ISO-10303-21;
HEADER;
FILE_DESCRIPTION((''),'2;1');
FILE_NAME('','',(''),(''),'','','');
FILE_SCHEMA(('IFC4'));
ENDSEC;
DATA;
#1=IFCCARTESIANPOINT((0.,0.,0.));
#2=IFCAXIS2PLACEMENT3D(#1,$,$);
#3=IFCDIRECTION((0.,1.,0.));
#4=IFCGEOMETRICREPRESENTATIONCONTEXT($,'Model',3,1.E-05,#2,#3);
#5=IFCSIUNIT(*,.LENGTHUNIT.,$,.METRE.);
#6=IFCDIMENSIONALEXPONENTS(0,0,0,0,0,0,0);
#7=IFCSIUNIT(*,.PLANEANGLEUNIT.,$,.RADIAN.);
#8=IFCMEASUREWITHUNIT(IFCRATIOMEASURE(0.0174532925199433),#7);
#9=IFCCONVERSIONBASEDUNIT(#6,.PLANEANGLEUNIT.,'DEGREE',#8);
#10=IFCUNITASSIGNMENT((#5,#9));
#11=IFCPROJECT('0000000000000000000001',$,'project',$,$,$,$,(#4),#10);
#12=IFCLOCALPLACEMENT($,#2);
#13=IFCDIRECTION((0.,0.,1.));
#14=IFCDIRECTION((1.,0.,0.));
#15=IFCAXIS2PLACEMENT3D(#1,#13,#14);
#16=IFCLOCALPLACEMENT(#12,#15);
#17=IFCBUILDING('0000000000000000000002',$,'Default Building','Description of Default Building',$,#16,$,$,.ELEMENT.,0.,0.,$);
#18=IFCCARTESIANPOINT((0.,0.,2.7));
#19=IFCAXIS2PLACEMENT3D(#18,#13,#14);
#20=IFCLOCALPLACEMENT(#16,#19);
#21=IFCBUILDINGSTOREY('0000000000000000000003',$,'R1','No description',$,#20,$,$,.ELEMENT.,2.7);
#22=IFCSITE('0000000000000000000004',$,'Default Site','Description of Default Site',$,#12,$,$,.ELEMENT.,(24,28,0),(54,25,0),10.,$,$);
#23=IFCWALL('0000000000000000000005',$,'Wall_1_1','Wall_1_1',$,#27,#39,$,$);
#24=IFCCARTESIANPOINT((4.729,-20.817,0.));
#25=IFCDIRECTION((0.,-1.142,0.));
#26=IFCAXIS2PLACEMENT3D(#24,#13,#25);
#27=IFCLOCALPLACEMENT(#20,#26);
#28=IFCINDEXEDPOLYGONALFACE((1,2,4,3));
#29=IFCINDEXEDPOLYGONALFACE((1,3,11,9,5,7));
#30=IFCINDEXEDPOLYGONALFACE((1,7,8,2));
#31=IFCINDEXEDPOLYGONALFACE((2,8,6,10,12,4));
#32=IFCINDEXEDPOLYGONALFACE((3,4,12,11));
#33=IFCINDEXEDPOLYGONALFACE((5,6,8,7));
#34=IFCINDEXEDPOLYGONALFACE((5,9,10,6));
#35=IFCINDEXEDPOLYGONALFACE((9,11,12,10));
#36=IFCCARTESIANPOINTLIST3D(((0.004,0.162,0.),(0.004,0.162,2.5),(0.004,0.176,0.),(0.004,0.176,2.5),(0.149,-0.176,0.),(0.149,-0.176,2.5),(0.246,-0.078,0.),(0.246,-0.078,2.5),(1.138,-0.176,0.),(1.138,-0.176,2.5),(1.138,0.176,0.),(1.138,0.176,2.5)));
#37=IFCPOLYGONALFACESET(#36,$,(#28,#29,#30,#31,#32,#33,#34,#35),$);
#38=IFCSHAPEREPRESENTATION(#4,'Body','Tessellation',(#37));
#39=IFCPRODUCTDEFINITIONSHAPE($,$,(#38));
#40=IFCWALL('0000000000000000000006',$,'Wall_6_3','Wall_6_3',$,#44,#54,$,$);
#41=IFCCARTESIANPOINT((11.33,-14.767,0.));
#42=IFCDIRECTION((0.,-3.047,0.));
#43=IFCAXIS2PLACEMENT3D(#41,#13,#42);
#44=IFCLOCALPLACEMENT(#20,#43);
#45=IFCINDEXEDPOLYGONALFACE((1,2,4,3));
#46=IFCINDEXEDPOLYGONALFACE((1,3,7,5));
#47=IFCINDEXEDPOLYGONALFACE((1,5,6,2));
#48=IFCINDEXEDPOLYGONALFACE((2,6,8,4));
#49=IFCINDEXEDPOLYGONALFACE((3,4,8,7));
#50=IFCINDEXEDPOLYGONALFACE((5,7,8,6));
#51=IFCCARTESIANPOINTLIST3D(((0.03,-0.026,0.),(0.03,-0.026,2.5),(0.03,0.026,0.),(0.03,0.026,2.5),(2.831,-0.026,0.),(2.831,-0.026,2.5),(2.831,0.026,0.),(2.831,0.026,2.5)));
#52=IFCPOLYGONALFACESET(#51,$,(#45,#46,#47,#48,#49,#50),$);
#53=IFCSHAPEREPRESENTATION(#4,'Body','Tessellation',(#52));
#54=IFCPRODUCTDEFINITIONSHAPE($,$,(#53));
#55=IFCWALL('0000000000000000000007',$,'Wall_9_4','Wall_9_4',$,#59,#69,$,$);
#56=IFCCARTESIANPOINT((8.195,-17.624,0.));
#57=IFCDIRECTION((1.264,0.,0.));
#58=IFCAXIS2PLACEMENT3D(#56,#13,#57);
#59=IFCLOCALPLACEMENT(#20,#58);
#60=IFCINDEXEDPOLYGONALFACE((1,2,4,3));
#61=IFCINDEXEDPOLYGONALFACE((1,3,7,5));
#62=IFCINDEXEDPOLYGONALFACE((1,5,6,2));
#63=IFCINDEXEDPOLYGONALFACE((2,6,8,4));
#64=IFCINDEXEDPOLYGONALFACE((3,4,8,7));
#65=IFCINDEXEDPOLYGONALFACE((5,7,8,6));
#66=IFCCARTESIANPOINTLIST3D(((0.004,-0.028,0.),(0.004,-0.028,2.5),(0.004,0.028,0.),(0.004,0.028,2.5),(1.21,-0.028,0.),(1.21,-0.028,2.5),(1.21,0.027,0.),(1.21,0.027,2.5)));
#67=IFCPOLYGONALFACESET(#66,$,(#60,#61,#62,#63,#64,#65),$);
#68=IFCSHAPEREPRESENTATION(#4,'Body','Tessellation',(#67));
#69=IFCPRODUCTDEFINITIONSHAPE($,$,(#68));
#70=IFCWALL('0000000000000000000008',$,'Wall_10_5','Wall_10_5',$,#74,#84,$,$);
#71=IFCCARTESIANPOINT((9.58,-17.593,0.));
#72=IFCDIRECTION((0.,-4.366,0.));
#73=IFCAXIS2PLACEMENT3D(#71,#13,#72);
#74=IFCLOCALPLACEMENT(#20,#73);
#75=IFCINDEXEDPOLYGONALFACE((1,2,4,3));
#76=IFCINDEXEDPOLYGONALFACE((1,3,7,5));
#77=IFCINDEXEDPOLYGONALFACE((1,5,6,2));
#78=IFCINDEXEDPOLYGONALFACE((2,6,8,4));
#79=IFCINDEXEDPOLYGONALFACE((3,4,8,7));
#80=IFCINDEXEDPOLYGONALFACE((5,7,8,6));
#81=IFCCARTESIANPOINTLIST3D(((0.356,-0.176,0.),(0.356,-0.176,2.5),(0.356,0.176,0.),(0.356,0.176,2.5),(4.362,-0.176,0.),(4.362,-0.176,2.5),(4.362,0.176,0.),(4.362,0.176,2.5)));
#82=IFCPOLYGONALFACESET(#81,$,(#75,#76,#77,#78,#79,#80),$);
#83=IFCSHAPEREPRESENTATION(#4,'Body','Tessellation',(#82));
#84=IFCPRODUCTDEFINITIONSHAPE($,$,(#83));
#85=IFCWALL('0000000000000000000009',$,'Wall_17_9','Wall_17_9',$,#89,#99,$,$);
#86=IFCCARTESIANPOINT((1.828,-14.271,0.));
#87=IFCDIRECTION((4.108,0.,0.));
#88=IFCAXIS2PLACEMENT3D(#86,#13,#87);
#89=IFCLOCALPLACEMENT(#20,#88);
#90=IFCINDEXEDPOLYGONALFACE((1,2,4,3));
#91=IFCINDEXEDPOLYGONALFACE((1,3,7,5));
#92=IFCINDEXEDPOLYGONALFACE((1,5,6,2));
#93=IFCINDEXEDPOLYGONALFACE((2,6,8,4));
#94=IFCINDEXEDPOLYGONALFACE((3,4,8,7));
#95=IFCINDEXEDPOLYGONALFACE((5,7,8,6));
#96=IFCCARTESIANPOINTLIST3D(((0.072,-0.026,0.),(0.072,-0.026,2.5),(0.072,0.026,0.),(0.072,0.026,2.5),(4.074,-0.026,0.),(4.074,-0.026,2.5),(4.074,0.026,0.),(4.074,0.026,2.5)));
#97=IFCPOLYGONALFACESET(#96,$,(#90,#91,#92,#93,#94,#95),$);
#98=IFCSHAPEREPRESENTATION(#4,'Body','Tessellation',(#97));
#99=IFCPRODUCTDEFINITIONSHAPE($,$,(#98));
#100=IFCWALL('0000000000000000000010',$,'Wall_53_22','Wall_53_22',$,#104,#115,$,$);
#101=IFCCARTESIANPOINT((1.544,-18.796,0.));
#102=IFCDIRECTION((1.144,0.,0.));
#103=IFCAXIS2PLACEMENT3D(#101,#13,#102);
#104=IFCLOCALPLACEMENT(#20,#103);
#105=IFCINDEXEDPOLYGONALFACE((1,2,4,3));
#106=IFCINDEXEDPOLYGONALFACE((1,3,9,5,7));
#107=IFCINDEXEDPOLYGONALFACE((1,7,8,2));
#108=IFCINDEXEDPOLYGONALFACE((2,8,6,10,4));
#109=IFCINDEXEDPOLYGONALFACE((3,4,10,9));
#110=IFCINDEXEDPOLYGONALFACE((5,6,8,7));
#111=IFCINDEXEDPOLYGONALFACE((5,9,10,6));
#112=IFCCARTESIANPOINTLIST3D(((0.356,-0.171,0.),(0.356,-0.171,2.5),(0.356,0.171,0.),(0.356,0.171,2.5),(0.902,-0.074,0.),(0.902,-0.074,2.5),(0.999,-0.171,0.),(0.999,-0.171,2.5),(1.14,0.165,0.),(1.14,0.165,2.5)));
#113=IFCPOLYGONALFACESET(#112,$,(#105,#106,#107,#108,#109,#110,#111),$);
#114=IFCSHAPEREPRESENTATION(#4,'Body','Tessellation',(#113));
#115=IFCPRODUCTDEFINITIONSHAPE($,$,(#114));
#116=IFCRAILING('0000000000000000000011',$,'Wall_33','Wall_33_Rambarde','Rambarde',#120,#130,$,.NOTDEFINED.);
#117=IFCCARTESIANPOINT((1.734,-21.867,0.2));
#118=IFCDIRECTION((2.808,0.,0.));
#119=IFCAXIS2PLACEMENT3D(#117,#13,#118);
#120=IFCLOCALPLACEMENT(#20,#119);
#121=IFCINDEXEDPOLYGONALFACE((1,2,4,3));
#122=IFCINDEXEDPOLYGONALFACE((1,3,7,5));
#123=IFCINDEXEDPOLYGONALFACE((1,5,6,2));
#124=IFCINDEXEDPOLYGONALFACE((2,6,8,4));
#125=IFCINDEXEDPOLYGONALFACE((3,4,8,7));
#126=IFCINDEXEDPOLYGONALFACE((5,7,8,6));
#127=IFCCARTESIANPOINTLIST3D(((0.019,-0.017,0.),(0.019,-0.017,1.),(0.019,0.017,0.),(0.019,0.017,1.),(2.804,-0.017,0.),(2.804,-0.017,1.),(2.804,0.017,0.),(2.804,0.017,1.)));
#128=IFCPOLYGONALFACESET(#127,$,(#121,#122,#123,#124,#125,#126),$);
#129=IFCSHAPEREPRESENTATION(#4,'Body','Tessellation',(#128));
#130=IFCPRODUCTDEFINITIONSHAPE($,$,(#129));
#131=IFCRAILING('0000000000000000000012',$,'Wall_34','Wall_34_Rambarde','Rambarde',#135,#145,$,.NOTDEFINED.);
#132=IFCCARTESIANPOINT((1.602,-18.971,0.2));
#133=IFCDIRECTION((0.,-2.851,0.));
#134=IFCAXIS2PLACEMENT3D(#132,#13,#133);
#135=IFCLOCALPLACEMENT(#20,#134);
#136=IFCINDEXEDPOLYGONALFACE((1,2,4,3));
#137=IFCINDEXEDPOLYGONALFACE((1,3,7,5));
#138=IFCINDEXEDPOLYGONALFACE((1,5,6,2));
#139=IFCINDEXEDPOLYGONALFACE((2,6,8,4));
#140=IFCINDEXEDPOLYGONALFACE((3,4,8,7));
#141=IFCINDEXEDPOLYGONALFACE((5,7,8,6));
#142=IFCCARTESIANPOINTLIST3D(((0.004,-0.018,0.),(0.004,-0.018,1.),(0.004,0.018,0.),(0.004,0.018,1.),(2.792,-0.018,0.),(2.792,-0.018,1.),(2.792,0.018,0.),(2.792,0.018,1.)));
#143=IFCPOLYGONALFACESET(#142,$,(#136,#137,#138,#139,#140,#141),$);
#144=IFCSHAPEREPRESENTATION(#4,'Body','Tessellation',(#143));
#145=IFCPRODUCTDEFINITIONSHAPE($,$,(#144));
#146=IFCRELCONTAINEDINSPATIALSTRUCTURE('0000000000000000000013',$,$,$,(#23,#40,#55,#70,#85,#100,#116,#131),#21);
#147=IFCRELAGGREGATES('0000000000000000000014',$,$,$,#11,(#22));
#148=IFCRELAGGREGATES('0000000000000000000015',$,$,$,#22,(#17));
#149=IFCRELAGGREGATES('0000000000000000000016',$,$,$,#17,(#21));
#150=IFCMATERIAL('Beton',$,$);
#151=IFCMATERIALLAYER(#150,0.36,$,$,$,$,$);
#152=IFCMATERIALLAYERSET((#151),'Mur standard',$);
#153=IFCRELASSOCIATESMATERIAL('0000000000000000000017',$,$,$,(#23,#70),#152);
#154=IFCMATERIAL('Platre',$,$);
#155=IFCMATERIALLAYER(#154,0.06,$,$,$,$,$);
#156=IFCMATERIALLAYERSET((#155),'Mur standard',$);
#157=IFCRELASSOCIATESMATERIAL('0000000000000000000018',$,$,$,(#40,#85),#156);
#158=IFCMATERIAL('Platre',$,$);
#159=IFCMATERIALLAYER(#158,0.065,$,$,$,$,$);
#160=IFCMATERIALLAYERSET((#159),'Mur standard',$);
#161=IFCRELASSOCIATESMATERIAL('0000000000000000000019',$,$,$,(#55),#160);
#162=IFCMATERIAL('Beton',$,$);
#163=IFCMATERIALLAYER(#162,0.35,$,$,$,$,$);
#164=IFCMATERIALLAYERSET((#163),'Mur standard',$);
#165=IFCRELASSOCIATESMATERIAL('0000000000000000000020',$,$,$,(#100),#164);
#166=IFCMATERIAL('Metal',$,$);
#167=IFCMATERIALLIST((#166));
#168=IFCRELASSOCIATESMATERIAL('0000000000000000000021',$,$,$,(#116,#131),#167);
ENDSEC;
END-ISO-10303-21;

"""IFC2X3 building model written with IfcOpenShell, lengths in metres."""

from ifc_helpers import new_model, entity, si_unit, converted_unit, direction, frame, origin, origin_with_axes, place, context, project, spatial, polyline, outline, extrude, material, material_list, layer, layer_set, layer_usage, element, save


model = new_model("IFC2X3")

# Units and contexts
model_context = context("Model", 3, precision=1e-05, world=origin(), true_north=direction((0.0, 1.0, 0.0)))
ifc_project = project(units=[si_unit("LENGTHUNIT", "METRE"), converted_unit("PLANEANGLEUNIT", "DEGREE", entity("IfcRatioMeasure", 0.0174532925199433), si_unit("PLANEANGLEUNIT", "RADIAN"), dimensions=[0, 0, 0, 0, 0, 0, 0])], contexts=[model_context])

# Site, building, storey
site_placement = place(None, origin())
site = spatial("IfcSite", under=ifc_project, at=site_placement, Name="Default Site", Description="Description of Default Site", CompositionType="ELEMENT", RefLatitude=(24, 28, 0), RefLongitude=(54, 25, 0), RefElevation=10.0)
building_placement = place(site_placement, origin_with_axes())
building = spatial("IfcBuilding", under=site, at=building_placement, Name="Default Building", Description="Description of Default Building", CompositionType="ELEMENT", ElevationOfRefHeight=0.0, ElevationOfTerrain=0.0)
storey_placement = place(building_placement, frame((0.0, 0.0, 2.7), z_axis=(0.0, 0.0, 1.0), x_axis=(1.0, 0.0, 0.0)))
storey = spatial("IfcBuildingStorey", under=building, at=storey_placement, Name="R1", Description="No description", CompositionType="ELEMENT", Elevation=2.7)

# Wall
ifc_material_1 = material(Name="Beton")
ifc_layer_1 = layer(ifc_material_1, 0.36)
ifc_layer_set_1 = layer_set([ifc_layer_1], Name="Mur standard")
ifc_layer_usage_1 = layer_usage(ifc_layer_set_1, "AXIS2", "NEGATIVE", 0.36)
wall_1_placement = place(storey_placement, frame((4.729, -20.817, 0.0), z_axis=(0.0, 0.0, 1.0), x_axis=(0.0, -1.142, 0.0)))
element("IfcWall", 1, at=wall_1_placement, inside=storey, material=ifc_layer_usage_1, Name="Wall_1_1", Description="Wall_1_1", context=model_context, shape_type="SweptSolid", body=[
    extrude(outline(polyline([(1.138, 0.176), (1.138, -0.176), (0.149, -0.176), (0.246, -0.078), (0.004, 0.162), (0.004, 0.176), (1.138, 0.176)])), origin(), (0.0, 0.0, 1.0), 2.5),
])

# Walls
ifc_material_2 = material(Name="Platre")
ifc_layer_2 = layer(ifc_material_2, 0.06)
ifc_layer_set_2 = layer_set([ifc_layer_2], Name="Mur standard")
ifc_layer_usage_2 = layer_usage(ifc_layer_set_2, "AXIS2", "NEGATIVE", 0.06)
wall_2_placement = place(storey_placement, frame((11.33, -14.767, 0.0), z_axis=(0.0, 0.0, 1.0), x_axis=(0.0, -3.047, 0.0)))
element("IfcWall", 2, at=wall_2_placement, inside=storey, material=ifc_layer_usage_2, Name="Wall_6_3", Description="Wall_6_3", context=model_context, shape_type="SweptSolid", body=[
    extrude(outline(polyline([(0.03, -0.026), (2.831, -0.026), (2.831, 0.026), (0.03, 0.026), (0.03, -0.026)])), origin(), (0.0, 0.0, 1.0), 2.5),
])
ifc_material_3 = material(Name="Platre")
ifc_layer_3 = layer(ifc_material_3, 0.065)
ifc_layer_set_3 = layer_set([ifc_layer_3], Name="Mur standard")
ifc_layer_usage_3 = layer_usage(ifc_layer_set_3, "AXIS2", "NEGATIVE", 0.065)
wall_3_placement = place(storey_placement, frame((8.195, -17.624, 0.0), z_axis=(0.0, 0.0, 1.0), x_axis=(1.264, 0.0, 0.0)))
element("IfcWall", 3, at=wall_3_placement, inside=storey, material=ifc_layer_usage_3, Name="Wall_9_4", Description="Wall_9_4", context=model_context, shape_type="SweptSolid", body=[
    extrude(outline(polyline([(1.21, 0.027), (1.21, -0.028), (0.004, -0.028), (0.004, 0.028), (1.21, 0.027)])), origin(), (0.0, 0.0, 1.0), 2.5),
])
wall_4_placement = place(storey_placement, frame((9.58, -17.593, 0.0), z_axis=(0.0, 0.0, 1.0), x_axis=(0.0, -4.366, 0.0)))
element("IfcWall", 4, at=wall_4_placement, inside=storey, material=ifc_layer_usage_1, Name="Wall_10_5", Description="Wall_10_5", context=model_context, shape_type="SweptSolid", body=[
    extrude(outline(polyline([(0.356, -0.176), (4.362, -0.176), (4.362, 0.176), (0.356, 0.176), (0.356, -0.176)])), origin(), (0.0, 0.0, 1.0), 2.5),
])

# Wall
wall_5_placement = place(storey_placement, frame((1.828, -14.271, 0.0), z_axis=(0.0, 0.0, 1.0), x_axis=(4.108, 0.0, 0.0)))
element("IfcWall", 5, at=wall_5_placement, inside=storey, material=ifc_layer_usage_2, Name="Wall_17_9", Description="Wall_17_9", context=model_context, shape_type="SweptSolid", body=[
    extrude(outline(polyline([(0.072, 0.026), (0.072, -0.026), (4.074, -0.026), (4.074, 0.026), (0.072, 0.026)])), origin(), (0.0, 0.0, 1.0), 2.5),
])

# Wall
ifc_material_4 = material(Name="Beton")
ifc_layer_4 = layer(ifc_material_4, 0.35)
ifc_layer_set_4 = layer_set([ifc_layer_4], Name="Mur standard")
ifc_layer_usage_4 = layer_usage(ifc_layer_set_4, "AXIS2", "NEGATIVE", 0.35)
wall_6_placement = place(storey_placement, frame((1.544, -18.796, 0.0), z_axis=(0.0, 0.0, 1.0), x_axis=(1.144, 0.0, 0.0)))
element("IfcWall", 6, at=wall_6_placement, inside=storey, material=ifc_layer_usage_4, Name="Wall_53_22", Description="Wall_53_22", context=model_context, shape_type="SweptSolid", body=[
    extrude(outline(polyline([(1.14, 0.165), (0.902, -0.074), (0.999, -0.171), (0.356, -0.171), (0.356, 0.171), (1.14, 0.165)])), origin(), (0.0, 0.0, 1.0), 2.5),
])

# Railings
ifc_material_5 = material(Name="Metal")
ifc_material_list_1 = material_list([ifc_material_5])
railing_1_placement = place(storey_placement, frame((1.734, -21.867, 0.2), z_axis=(0.0, 0.0, 1.0), x_axis=(2.808, 0.0, 0.0)))
element("IfcRailing", 7, at=railing_1_placement, inside=storey, material=ifc_material_list_1, Name="Wall_33", Description="Wall_33_Rambarde", ObjectType="Rambarde", PredefinedType="NOTDEFINED", context=model_context, shape_type="SweptSolid", body=[
    extrude(outline(polyline([(0.019, 0.017), (0.019, -0.017), (2.804, -0.017), (2.804, 0.017), (0.019, 0.017)])), origin(), (0.0, 0.0, 1.0), 1.0),
])
railing_2_placement = place(storey_placement, frame((1.602, -18.971, 0.2), z_axis=(0.0, 0.0, 1.0), x_axis=(0.0, -2.851, 0.0)))
element("IfcRailing", 8, at=railing_2_placement, inside=storey, material=ifc_material_list_1, Name="Wall_34", Description="Wall_34_Rambarde", ObjectType="Rambarde", PredefinedType="NOTDEFINED", context=model_context, shape_type="SweptSolid", body=[
    extrude(outline(polyline([(0.004, -0.018), (2.792, -0.018), (2.792, 0.018), (0.004, 0.018), (0.004, -0.018)])), origin(), (0.0, 0.0, 1.0), 1.0),
])

save(model, "model.ifc")
